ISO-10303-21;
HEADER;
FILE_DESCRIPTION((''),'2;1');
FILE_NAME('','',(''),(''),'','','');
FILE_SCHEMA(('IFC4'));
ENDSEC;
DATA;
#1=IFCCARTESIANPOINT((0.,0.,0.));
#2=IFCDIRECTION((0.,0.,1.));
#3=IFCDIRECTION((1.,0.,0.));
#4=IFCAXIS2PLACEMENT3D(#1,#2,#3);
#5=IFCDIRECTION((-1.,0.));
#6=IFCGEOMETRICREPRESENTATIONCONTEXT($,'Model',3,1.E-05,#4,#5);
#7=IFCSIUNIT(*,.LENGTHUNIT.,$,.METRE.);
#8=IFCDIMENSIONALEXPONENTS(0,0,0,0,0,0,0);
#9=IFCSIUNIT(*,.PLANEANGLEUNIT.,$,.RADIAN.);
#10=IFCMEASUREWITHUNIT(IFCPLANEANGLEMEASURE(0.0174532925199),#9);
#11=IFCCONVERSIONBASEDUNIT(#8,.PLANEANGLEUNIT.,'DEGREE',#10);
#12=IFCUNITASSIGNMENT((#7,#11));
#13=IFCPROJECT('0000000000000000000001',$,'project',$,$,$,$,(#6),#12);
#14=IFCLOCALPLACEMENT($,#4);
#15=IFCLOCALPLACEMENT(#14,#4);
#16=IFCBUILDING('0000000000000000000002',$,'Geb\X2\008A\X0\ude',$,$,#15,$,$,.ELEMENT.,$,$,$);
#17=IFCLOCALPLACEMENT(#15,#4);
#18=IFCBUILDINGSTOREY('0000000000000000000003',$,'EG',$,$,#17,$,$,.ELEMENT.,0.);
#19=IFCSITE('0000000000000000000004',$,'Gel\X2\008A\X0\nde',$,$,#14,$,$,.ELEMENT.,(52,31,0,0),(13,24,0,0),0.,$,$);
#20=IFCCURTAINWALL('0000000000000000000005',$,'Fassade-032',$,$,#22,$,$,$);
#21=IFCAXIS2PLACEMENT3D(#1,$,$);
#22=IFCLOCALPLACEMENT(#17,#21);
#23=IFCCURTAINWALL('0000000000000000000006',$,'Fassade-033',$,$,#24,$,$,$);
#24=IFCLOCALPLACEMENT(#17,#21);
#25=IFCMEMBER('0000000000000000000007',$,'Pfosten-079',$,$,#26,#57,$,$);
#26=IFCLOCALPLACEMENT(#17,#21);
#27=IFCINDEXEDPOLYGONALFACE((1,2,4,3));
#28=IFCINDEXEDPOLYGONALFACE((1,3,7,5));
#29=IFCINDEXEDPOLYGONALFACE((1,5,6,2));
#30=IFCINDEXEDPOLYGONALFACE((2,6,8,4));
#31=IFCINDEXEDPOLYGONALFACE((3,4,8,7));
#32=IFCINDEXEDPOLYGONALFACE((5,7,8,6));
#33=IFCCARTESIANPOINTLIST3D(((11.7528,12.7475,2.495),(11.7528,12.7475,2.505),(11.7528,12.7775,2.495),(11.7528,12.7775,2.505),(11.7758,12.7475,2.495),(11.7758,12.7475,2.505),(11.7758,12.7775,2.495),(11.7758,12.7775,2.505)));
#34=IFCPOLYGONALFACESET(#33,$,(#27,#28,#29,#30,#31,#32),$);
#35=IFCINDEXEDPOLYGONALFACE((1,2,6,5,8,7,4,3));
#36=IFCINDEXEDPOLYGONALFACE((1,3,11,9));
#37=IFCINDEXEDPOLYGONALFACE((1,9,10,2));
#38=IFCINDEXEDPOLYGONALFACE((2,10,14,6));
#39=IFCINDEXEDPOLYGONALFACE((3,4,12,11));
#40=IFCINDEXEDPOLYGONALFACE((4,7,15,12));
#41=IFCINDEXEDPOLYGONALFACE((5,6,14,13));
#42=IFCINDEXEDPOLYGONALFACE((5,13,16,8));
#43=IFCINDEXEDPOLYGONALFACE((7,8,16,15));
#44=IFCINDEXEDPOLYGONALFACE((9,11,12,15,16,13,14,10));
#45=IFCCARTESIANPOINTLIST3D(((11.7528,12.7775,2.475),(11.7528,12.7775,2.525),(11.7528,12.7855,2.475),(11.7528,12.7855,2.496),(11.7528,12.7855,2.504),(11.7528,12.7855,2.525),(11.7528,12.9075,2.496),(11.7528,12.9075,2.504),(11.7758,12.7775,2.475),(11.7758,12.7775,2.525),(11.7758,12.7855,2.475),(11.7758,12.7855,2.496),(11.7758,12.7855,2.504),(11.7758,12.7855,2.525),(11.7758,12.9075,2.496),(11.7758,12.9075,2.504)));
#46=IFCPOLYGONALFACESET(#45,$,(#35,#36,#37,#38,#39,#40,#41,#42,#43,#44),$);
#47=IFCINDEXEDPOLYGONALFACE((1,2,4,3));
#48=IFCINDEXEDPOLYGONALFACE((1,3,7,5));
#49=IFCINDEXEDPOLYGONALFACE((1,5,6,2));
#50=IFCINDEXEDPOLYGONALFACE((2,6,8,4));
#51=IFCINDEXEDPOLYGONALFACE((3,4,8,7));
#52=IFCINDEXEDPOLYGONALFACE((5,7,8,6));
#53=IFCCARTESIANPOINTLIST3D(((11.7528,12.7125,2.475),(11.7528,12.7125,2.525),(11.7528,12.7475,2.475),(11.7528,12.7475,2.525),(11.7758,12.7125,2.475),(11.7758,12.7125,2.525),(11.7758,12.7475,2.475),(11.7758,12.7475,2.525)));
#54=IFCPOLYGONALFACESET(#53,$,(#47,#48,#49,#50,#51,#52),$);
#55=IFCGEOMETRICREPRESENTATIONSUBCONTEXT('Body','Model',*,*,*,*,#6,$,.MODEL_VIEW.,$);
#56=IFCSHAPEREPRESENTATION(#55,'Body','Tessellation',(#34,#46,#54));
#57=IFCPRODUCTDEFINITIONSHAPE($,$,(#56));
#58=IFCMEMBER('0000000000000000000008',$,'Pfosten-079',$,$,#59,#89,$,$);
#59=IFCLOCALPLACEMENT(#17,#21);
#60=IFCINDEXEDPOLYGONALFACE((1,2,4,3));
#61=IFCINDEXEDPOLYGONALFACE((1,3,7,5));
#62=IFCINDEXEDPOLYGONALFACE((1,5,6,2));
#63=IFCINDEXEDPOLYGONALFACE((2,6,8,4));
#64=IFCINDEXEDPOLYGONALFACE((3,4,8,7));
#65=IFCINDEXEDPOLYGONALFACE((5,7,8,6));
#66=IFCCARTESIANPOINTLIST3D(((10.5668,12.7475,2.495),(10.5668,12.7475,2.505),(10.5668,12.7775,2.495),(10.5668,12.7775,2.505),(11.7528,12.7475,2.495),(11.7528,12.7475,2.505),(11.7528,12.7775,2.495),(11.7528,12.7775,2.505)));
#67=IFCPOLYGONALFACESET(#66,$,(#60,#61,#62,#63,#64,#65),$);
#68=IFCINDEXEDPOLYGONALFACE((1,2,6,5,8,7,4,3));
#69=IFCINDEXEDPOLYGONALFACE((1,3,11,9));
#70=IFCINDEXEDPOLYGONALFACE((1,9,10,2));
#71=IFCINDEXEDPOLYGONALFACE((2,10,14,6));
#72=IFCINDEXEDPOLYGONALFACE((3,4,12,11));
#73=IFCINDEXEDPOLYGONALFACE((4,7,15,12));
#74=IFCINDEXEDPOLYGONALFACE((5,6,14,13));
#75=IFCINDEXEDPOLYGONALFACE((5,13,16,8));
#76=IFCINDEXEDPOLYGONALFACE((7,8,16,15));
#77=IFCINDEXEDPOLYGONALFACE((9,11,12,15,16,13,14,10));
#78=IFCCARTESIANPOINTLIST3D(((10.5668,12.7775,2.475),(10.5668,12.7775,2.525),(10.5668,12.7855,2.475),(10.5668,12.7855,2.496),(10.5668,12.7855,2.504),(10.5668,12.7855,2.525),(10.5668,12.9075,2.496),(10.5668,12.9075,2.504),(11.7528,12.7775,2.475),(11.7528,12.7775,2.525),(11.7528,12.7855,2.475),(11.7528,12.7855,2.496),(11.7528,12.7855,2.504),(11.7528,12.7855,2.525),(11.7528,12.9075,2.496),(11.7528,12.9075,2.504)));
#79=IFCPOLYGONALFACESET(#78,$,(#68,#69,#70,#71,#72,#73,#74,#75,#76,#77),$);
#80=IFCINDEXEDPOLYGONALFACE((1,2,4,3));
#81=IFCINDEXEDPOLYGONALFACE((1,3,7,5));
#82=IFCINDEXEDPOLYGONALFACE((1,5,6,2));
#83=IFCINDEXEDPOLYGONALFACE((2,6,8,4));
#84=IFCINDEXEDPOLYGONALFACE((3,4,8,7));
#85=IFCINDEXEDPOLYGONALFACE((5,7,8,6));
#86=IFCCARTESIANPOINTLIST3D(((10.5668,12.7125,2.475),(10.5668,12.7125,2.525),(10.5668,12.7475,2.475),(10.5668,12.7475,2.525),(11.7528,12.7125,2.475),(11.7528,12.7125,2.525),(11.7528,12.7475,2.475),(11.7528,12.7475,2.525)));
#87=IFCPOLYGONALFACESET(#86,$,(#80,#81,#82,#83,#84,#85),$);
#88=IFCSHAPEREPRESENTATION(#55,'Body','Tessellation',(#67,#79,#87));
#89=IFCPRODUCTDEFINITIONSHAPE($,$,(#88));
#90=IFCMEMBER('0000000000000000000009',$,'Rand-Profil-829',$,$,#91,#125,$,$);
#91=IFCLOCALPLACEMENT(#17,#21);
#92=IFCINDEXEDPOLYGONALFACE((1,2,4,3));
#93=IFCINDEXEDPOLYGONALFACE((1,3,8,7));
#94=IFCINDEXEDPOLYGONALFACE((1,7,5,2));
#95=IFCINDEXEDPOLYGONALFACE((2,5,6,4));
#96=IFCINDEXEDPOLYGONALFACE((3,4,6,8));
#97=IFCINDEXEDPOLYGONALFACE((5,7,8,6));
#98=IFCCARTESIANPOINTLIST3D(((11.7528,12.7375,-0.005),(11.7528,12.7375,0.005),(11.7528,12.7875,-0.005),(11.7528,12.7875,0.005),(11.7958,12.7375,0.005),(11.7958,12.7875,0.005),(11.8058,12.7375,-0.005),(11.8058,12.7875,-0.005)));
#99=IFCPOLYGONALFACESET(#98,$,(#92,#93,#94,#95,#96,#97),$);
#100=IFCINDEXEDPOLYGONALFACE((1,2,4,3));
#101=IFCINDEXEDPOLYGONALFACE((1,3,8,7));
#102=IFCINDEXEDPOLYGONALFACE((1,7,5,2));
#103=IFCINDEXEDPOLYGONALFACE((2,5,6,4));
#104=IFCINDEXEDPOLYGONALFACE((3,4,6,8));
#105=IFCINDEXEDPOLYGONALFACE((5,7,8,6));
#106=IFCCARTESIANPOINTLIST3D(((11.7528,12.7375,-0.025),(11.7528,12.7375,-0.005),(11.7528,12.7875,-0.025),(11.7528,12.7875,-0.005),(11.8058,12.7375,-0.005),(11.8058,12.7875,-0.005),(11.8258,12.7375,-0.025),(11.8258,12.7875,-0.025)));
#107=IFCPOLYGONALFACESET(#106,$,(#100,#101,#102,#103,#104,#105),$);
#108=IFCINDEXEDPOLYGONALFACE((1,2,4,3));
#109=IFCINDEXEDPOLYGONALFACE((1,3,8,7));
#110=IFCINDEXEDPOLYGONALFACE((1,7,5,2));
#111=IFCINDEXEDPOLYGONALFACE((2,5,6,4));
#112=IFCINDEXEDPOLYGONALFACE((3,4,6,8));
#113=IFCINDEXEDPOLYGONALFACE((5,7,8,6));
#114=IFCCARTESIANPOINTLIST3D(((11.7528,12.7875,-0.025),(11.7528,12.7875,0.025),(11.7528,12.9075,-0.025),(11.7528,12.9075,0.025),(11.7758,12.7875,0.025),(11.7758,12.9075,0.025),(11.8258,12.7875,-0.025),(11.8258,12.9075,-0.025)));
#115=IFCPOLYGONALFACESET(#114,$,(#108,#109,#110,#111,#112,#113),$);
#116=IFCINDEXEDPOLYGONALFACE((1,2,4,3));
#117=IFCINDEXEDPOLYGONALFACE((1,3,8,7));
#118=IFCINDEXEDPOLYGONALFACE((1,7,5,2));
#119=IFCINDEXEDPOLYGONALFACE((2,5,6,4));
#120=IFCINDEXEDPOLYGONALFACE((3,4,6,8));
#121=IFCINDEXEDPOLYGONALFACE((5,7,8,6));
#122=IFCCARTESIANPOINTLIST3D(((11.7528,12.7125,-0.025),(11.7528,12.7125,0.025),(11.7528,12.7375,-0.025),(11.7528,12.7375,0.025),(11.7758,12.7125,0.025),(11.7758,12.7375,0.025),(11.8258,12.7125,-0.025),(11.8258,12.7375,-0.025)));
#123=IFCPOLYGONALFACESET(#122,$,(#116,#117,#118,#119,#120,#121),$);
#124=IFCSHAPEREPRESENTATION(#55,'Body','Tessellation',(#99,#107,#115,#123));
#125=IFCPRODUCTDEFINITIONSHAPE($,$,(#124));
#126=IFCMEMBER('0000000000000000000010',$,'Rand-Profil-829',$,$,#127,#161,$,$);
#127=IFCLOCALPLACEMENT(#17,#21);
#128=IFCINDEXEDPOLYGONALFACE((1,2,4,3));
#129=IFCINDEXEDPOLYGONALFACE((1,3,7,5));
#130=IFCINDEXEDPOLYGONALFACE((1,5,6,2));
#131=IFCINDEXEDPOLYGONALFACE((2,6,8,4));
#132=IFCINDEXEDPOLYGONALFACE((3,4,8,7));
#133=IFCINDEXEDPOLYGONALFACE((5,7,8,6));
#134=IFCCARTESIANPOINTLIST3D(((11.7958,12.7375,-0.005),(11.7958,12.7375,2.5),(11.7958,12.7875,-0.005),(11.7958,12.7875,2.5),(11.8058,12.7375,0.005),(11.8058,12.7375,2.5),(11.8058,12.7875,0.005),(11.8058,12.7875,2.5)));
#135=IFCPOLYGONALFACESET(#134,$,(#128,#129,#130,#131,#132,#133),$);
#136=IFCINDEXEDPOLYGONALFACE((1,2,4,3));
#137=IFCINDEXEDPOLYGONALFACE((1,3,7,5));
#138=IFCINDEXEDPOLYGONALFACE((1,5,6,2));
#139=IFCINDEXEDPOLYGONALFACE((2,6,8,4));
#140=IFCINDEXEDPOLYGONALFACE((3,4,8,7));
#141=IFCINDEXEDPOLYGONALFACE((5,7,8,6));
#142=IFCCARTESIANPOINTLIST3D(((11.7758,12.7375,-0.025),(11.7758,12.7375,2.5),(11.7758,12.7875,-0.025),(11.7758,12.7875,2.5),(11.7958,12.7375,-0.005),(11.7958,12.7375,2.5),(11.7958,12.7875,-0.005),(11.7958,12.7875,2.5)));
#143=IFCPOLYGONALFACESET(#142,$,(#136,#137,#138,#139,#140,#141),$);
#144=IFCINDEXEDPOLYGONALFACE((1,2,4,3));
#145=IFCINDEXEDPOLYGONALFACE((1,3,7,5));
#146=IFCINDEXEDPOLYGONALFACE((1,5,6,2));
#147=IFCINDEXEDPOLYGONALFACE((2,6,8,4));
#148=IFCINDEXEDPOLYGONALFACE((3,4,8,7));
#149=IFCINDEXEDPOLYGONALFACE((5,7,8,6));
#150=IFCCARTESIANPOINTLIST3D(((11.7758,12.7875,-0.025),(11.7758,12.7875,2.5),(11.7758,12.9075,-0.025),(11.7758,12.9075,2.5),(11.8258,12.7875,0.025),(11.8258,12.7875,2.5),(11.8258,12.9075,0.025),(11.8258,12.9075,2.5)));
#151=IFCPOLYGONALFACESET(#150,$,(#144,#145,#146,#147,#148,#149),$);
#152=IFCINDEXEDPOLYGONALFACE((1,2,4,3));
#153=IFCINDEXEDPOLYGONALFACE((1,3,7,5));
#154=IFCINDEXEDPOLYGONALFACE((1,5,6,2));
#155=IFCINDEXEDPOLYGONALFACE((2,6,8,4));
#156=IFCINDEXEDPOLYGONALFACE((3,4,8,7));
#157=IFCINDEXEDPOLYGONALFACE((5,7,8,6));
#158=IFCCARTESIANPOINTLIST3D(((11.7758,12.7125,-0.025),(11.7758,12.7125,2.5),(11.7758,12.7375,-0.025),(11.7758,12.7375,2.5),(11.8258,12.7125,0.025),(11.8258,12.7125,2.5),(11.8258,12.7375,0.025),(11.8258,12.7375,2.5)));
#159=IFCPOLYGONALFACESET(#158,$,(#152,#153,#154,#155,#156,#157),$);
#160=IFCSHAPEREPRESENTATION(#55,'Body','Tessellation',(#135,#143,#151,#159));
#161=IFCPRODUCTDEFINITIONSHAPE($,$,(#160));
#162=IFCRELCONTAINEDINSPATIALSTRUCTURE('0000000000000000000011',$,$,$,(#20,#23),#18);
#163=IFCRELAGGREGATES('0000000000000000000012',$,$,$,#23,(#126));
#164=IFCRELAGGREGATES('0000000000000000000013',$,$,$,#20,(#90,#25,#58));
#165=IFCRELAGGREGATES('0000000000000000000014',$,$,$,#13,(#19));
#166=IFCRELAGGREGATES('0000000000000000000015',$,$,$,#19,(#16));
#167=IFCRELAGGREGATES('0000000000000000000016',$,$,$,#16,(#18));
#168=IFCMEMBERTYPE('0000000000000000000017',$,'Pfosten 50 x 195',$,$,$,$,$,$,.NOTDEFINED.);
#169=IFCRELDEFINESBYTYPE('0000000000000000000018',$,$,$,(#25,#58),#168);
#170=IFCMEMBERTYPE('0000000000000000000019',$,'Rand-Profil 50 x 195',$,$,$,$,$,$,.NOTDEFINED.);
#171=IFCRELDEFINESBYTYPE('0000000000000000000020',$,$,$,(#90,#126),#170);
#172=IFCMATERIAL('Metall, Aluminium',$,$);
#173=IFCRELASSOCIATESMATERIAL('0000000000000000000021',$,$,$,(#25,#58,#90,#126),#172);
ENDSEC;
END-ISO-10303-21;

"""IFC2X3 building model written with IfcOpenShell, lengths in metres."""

from ifc_helpers import new_model, entity, si_unit, converted_unit, direction, frame, origin_with_axes, place, context, subcontext, project, spatial, polyline, outline, extrude, clip, halfspace, material, type_object, element, aggregate, save


model = new_model("IFC2X3")

# Units and contexts
model_context = context("Model", 3, precision=1e-05, world=origin_with_axes(), true_north=direction((-1.0, 0.0)))
body_context = subcontext(model_context, "Body", "Model", "MODEL_VIEW")
ifc_project = project(units=[si_unit("LENGTHUNIT", "METRE"), converted_unit("PLANEANGLEUNIT", "DEGREE", entity("IfcPlaneAngleMeasure", 0.0174532925199), si_unit("PLANEANGLEUNIT", "RADIAN"), dimensions=[0, 0, 0, 0, 0, 0, 0])], contexts=[model_context])

# Site, building, storey
site_placement = place(None, origin_with_axes())
site = spatial("IfcSite", under=ifc_project, at=site_placement, Name="Gel\u008ande", CompositionType="ELEMENT", RefLatitude=(52, 31, 0, 0), RefLongitude=(13, 24, 0, 0), RefElevation=0.0)
building_placement = place(site_placement, origin_with_axes())
building = spatial("IfcBuilding", under=site, at=building_placement, Name="Geb\u008aude", CompositionType="ELEMENT")
storey_placement = place(building_placement, origin_with_axes())
storey = spatial("IfcBuildingStorey", under=building, at=storey_placement, Name="EG", CompositionType="ELEMENT", Elevation=0.0)

# Curtain wall
curtain_wall_1_placement = place(storey_placement, frame((9.9738, 12.7625, 0.0), z_axis=(0.0, 0.0, 1.0), x_axis=(1.0, 0.0, 0.0)))
curtain_wall_1 = element("IfcCurtainWall", 1, at=curtain_wall_1_placement, inside=storey, Name="Fassade-032")
ifc_material = material(Name="Metall, Aluminium")

# Curtain wall
curtain_wall_2_placement = place(storey_placement, frame((12.3938, 12.7625, 0.0), z_axis=(0.0, 0.0, 1.0), x_axis=(1.0, 0.0, 0.0)))
curtain_wall_2 = element("IfcCurtainWall", 2, at=curtain_wall_2_placement, inside=storey, Name="Fassade-033")
member_type_1 = type_object("IfcMemberType", Name="Pfosten 50 x 195", PredefinedType="NOTDEFINED")

# Members
member_1_placement = place(curtain_wall_1_placement, frame((1.779, 0.0, 2.5), z_axis=(1.0, 0.0, 0.0), x_axis=(0.0, 0.0, 1.0)))
member_1 = element("IfcMember", 3, at=member_1_placement, type_object=member_type_1, material=ifc_material, Name="Pfosten-079", context=body_context, shape_type="SweptSolid", body=[
    extrude(outline(polyline([(-0.015, -0.005), (0.015, -0.005), (0.015, 0.005), (-0.015, 0.005), (-0.015, -0.005)])), frame((0.0, 0.0, 0.0), z_axis=(0.0, 0.0, 1.0), x_axis=(0.0, 1.0, 0.0)), (0.0, 0.0, 1.0), 0.023),
    extrude(outline(polyline([(-0.145, -0.004), (-0.023, -0.004), (-0.023, -0.025), (-0.015, -0.025), (-0.015, 0.025), (-0.023, 0.025), (-0.023, 0.004), (-0.145, 0.004), (-0.145, -0.004)])), frame((0.0, 0.0, 0.0), z_axis=(0.0, 0.0, 1.0), x_axis=(0.0, 1.0, 0.0)), (0.0, 0.0, 1.0), 0.023),
    extrude(outline(polyline([(0.05, 0.025), (0.015, 0.025), (0.015, -0.025), (0.05, -0.025), (0.05, 0.025)])), frame((0.0, 0.0, 0.0), z_axis=(0.0, 0.0, 1.0), x_axis=(0.0, 1.0, 0.0)), (0.0, 0.0, 1.0), 0.023),
])
member_2_placement = place(curtain_wall_1_placement, frame((0.593, 0.0, 2.5), z_axis=(1.0, 0.0, 0.0), x_axis=(0.0, 0.0, 1.0)))
member_2 = element("IfcMember", 4, at=member_2_placement, type_object=member_type_1, material=ifc_material, Name="Pfosten-079", context=body_context, shape_type="SweptSolid", body=[
    extrude(outline(polyline([(-0.015, -0.005), (0.015, -0.005), (0.015, 0.005), (-0.015, 0.005), (-0.015, -0.005)])), frame((0.0, 0.0, 0.0), z_axis=(0.0, 0.0, 1.0), x_axis=(0.0, 1.0, 0.0)), (0.0, 0.0, 1.0), 1.186),
    extrude(outline(polyline([(-0.145, -0.004), (-0.023, -0.004), (-0.023, -0.025), (-0.015, -0.025), (-0.015, 0.025), (-0.023, 0.025), (-0.023, 0.004), (-0.145, 0.004), (-0.145, -0.004)])), frame((0.0, 0.0, 0.0), z_axis=(0.0, 0.0, 1.0), x_axis=(0.0, 1.0, 0.0)), (0.0, 0.0, 1.0), 1.186),
    extrude(outline(polyline([(0.05, 0.025), (0.015, 0.025), (0.015, -0.025), (0.05, -0.025), (0.05, 0.025)])), frame((0.0, 0.0, 0.0), z_axis=(0.0, 0.0, 1.0), x_axis=(0.0, 1.0, 0.0)), (0.0, 0.0, 1.0), 1.186),
])
member_type_2 = type_object("IfcMemberType", Name="Rand-Profil 50 x 195", PredefinedType="NOTDEFINED")
member_3_placement = place(curtain_wall_1_placement, frame((1.779, 0.0, 0.0), z_axis=(1.0, 0.0, 0.0), x_axis=(0.0, 0.0, 1.0)))
member_3 = element("IfcMember", 5, at=member_3_placement, type_object=member_type_2, material=ifc_material, Name="Rand-Profil-829", context=body_context, shape_type="Clipping", body=[
    clip(extrude(outline(polyline([(-0.025, -0.005), (0.025, -0.005), (0.025, 0.005), (-0.025, 0.005), (-0.025, -0.005)])), frame((0.0, 0.0, 0.0), z_axis=(0.0, 0.0, 1.0), x_axis=(0.0, 1.0, 0.0)), (0.0, 0.0, 1.0), 0.053), halfspace(frame((0.024, 0.0, 0.024), z_axis=(-0.707107, 0.0, -0.707107), x_axis=(0.707107, 0.0, -0.707107)), True)),
    clip(extrude(outline(polyline([(-0.025, 0.005), (0.025, 0.005), (0.025, 0.025), (-0.025, 0.025), (-0.025, 0.005)])), frame((0.0, 0.0, 0.0), z_axis=(0.0, 0.0, 1.0), x_axis=(0.0, 1.0, 0.0)), (0.0, 0.0, 1.0), 0.073), halfspace(frame((0.024, 0.0, 0.024), z_axis=(-0.707107, 0.0, -0.707107), x_axis=(0.707107, 0.0, -0.707107)), True)),
    clip(extrude(outline(polyline([(-0.145, -0.025), (-0.025, -0.025), (-0.025, 0.025), (-0.145, 0.025), (-0.145, -0.025)])), frame((0.0, 0.0, 0.0), z_axis=(0.0, 0.0, 1.0), x_axis=(0.0, 1.0, 0.0)), (0.0, 0.0, 1.0), 0.073), halfspace(frame((0.024, 0.0, 0.024), z_axis=(-0.707107, 0.0, -0.707107), x_axis=(0.707107, 0.0, -0.707107)), True)),
    clip(extrude(outline(polyline([(0.05, 0.025), (0.025, 0.025), (0.025, -0.025), (0.05, -0.025), (0.05, 0.025)])), frame((0.0, 0.0, 0.0), z_axis=(0.0, 0.0, 1.0), x_axis=(0.0, 1.0, 0.0)), (0.0, 0.0, 1.0), 0.073), halfspace(frame((0.024, 0.0, 0.024), z_axis=(-0.707107, 0.0, -0.707107), x_axis=(0.707107, 0.0, -0.707107)), True)),
])
member_4_placement = place(curtain_wall_2_placement, frame((-0.593, 0.0, 0.0), z_axis=(0.0, 0.0, 1.0), x_axis=(-1.0, 0.0, 0.0)))
member_4 = element("IfcMember", 6, at=member_4_placement, type_object=member_type_2, material=ifc_material, Name="Rand-Profil-829", context=body_context, shape_type="Clipping", body=[
    clip(extrude(outline(polyline([(-0.005, 0.025), (-0.005, -0.025), (0.005, -0.025), (0.005, 0.025), (-0.005, 0.025)])), frame((0.0, 0.0, -0.005), z_axis=(0.0, 0.0, 1.0), x_axis=(-1.0, 0.0, 0.0)), (0.0, 0.0, 1.0), 2.505), halfspace(frame((0.0, 0.0, 0.0), z_axis=(0.707107, 0.0, 0.707107), x_axis=(-0.707107, 0.0, 0.707107)), True)),
    clip(extrude(outline(polyline([(-0.025, 0.025), (-0.025, -0.025), (-0.005, -0.025), (-0.005, 0.025), (-0.025, 0.025)])), frame((0.0, 0.0, -0.025), z_axis=(0.0, 0.0, 1.0), x_axis=(-1.0, 0.0, 0.0)), (0.0, 0.0, 1.0), 2.525), halfspace(frame((0.0, 0.0, 0.0), z_axis=(0.707107, 0.0, 0.707107), x_axis=(-0.707107, 0.0, 0.707107)), True)),
    clip(extrude(outline(polyline([(-0.025, 0.145), (-0.025, 0.025), (0.025, 0.025), (0.025, 0.145), (-0.025, 0.145)])), frame((0.0, 0.0, -0.025), z_axis=(0.0, 0.0, 1.0), x_axis=(-1.0, 0.0, 0.0)), (0.0, 0.0, 1.0), 2.525), halfspace(frame((0.0, 0.0, 0.0), z_axis=(0.707107, 0.0, 0.707107), x_axis=(-0.707107, 0.0, 0.707107)), True)),
    clip(extrude(outline(polyline([(0.025, -0.05), (0.025, -0.025), (-0.025, -0.025), (-0.025, -0.05), (0.025, -0.05)])), frame((0.0, 0.0, -0.025), z_axis=(0.0, 0.0, 1.0), x_axis=(-1.0, 0.0, 0.0)), (0.0, 0.0, 1.0), 2.525), halfspace(frame((0.0, 0.0, 0.0), z_axis=(0.707107, 0.0, 0.707107), x_axis=(-0.707107, 0.0, 0.707107)), True)),
])

aggregate(curtain_wall_2, [member_4])
aggregate(curtain_wall_1, [member_3, member_1, member_2])

save(model, "model.ifc")
